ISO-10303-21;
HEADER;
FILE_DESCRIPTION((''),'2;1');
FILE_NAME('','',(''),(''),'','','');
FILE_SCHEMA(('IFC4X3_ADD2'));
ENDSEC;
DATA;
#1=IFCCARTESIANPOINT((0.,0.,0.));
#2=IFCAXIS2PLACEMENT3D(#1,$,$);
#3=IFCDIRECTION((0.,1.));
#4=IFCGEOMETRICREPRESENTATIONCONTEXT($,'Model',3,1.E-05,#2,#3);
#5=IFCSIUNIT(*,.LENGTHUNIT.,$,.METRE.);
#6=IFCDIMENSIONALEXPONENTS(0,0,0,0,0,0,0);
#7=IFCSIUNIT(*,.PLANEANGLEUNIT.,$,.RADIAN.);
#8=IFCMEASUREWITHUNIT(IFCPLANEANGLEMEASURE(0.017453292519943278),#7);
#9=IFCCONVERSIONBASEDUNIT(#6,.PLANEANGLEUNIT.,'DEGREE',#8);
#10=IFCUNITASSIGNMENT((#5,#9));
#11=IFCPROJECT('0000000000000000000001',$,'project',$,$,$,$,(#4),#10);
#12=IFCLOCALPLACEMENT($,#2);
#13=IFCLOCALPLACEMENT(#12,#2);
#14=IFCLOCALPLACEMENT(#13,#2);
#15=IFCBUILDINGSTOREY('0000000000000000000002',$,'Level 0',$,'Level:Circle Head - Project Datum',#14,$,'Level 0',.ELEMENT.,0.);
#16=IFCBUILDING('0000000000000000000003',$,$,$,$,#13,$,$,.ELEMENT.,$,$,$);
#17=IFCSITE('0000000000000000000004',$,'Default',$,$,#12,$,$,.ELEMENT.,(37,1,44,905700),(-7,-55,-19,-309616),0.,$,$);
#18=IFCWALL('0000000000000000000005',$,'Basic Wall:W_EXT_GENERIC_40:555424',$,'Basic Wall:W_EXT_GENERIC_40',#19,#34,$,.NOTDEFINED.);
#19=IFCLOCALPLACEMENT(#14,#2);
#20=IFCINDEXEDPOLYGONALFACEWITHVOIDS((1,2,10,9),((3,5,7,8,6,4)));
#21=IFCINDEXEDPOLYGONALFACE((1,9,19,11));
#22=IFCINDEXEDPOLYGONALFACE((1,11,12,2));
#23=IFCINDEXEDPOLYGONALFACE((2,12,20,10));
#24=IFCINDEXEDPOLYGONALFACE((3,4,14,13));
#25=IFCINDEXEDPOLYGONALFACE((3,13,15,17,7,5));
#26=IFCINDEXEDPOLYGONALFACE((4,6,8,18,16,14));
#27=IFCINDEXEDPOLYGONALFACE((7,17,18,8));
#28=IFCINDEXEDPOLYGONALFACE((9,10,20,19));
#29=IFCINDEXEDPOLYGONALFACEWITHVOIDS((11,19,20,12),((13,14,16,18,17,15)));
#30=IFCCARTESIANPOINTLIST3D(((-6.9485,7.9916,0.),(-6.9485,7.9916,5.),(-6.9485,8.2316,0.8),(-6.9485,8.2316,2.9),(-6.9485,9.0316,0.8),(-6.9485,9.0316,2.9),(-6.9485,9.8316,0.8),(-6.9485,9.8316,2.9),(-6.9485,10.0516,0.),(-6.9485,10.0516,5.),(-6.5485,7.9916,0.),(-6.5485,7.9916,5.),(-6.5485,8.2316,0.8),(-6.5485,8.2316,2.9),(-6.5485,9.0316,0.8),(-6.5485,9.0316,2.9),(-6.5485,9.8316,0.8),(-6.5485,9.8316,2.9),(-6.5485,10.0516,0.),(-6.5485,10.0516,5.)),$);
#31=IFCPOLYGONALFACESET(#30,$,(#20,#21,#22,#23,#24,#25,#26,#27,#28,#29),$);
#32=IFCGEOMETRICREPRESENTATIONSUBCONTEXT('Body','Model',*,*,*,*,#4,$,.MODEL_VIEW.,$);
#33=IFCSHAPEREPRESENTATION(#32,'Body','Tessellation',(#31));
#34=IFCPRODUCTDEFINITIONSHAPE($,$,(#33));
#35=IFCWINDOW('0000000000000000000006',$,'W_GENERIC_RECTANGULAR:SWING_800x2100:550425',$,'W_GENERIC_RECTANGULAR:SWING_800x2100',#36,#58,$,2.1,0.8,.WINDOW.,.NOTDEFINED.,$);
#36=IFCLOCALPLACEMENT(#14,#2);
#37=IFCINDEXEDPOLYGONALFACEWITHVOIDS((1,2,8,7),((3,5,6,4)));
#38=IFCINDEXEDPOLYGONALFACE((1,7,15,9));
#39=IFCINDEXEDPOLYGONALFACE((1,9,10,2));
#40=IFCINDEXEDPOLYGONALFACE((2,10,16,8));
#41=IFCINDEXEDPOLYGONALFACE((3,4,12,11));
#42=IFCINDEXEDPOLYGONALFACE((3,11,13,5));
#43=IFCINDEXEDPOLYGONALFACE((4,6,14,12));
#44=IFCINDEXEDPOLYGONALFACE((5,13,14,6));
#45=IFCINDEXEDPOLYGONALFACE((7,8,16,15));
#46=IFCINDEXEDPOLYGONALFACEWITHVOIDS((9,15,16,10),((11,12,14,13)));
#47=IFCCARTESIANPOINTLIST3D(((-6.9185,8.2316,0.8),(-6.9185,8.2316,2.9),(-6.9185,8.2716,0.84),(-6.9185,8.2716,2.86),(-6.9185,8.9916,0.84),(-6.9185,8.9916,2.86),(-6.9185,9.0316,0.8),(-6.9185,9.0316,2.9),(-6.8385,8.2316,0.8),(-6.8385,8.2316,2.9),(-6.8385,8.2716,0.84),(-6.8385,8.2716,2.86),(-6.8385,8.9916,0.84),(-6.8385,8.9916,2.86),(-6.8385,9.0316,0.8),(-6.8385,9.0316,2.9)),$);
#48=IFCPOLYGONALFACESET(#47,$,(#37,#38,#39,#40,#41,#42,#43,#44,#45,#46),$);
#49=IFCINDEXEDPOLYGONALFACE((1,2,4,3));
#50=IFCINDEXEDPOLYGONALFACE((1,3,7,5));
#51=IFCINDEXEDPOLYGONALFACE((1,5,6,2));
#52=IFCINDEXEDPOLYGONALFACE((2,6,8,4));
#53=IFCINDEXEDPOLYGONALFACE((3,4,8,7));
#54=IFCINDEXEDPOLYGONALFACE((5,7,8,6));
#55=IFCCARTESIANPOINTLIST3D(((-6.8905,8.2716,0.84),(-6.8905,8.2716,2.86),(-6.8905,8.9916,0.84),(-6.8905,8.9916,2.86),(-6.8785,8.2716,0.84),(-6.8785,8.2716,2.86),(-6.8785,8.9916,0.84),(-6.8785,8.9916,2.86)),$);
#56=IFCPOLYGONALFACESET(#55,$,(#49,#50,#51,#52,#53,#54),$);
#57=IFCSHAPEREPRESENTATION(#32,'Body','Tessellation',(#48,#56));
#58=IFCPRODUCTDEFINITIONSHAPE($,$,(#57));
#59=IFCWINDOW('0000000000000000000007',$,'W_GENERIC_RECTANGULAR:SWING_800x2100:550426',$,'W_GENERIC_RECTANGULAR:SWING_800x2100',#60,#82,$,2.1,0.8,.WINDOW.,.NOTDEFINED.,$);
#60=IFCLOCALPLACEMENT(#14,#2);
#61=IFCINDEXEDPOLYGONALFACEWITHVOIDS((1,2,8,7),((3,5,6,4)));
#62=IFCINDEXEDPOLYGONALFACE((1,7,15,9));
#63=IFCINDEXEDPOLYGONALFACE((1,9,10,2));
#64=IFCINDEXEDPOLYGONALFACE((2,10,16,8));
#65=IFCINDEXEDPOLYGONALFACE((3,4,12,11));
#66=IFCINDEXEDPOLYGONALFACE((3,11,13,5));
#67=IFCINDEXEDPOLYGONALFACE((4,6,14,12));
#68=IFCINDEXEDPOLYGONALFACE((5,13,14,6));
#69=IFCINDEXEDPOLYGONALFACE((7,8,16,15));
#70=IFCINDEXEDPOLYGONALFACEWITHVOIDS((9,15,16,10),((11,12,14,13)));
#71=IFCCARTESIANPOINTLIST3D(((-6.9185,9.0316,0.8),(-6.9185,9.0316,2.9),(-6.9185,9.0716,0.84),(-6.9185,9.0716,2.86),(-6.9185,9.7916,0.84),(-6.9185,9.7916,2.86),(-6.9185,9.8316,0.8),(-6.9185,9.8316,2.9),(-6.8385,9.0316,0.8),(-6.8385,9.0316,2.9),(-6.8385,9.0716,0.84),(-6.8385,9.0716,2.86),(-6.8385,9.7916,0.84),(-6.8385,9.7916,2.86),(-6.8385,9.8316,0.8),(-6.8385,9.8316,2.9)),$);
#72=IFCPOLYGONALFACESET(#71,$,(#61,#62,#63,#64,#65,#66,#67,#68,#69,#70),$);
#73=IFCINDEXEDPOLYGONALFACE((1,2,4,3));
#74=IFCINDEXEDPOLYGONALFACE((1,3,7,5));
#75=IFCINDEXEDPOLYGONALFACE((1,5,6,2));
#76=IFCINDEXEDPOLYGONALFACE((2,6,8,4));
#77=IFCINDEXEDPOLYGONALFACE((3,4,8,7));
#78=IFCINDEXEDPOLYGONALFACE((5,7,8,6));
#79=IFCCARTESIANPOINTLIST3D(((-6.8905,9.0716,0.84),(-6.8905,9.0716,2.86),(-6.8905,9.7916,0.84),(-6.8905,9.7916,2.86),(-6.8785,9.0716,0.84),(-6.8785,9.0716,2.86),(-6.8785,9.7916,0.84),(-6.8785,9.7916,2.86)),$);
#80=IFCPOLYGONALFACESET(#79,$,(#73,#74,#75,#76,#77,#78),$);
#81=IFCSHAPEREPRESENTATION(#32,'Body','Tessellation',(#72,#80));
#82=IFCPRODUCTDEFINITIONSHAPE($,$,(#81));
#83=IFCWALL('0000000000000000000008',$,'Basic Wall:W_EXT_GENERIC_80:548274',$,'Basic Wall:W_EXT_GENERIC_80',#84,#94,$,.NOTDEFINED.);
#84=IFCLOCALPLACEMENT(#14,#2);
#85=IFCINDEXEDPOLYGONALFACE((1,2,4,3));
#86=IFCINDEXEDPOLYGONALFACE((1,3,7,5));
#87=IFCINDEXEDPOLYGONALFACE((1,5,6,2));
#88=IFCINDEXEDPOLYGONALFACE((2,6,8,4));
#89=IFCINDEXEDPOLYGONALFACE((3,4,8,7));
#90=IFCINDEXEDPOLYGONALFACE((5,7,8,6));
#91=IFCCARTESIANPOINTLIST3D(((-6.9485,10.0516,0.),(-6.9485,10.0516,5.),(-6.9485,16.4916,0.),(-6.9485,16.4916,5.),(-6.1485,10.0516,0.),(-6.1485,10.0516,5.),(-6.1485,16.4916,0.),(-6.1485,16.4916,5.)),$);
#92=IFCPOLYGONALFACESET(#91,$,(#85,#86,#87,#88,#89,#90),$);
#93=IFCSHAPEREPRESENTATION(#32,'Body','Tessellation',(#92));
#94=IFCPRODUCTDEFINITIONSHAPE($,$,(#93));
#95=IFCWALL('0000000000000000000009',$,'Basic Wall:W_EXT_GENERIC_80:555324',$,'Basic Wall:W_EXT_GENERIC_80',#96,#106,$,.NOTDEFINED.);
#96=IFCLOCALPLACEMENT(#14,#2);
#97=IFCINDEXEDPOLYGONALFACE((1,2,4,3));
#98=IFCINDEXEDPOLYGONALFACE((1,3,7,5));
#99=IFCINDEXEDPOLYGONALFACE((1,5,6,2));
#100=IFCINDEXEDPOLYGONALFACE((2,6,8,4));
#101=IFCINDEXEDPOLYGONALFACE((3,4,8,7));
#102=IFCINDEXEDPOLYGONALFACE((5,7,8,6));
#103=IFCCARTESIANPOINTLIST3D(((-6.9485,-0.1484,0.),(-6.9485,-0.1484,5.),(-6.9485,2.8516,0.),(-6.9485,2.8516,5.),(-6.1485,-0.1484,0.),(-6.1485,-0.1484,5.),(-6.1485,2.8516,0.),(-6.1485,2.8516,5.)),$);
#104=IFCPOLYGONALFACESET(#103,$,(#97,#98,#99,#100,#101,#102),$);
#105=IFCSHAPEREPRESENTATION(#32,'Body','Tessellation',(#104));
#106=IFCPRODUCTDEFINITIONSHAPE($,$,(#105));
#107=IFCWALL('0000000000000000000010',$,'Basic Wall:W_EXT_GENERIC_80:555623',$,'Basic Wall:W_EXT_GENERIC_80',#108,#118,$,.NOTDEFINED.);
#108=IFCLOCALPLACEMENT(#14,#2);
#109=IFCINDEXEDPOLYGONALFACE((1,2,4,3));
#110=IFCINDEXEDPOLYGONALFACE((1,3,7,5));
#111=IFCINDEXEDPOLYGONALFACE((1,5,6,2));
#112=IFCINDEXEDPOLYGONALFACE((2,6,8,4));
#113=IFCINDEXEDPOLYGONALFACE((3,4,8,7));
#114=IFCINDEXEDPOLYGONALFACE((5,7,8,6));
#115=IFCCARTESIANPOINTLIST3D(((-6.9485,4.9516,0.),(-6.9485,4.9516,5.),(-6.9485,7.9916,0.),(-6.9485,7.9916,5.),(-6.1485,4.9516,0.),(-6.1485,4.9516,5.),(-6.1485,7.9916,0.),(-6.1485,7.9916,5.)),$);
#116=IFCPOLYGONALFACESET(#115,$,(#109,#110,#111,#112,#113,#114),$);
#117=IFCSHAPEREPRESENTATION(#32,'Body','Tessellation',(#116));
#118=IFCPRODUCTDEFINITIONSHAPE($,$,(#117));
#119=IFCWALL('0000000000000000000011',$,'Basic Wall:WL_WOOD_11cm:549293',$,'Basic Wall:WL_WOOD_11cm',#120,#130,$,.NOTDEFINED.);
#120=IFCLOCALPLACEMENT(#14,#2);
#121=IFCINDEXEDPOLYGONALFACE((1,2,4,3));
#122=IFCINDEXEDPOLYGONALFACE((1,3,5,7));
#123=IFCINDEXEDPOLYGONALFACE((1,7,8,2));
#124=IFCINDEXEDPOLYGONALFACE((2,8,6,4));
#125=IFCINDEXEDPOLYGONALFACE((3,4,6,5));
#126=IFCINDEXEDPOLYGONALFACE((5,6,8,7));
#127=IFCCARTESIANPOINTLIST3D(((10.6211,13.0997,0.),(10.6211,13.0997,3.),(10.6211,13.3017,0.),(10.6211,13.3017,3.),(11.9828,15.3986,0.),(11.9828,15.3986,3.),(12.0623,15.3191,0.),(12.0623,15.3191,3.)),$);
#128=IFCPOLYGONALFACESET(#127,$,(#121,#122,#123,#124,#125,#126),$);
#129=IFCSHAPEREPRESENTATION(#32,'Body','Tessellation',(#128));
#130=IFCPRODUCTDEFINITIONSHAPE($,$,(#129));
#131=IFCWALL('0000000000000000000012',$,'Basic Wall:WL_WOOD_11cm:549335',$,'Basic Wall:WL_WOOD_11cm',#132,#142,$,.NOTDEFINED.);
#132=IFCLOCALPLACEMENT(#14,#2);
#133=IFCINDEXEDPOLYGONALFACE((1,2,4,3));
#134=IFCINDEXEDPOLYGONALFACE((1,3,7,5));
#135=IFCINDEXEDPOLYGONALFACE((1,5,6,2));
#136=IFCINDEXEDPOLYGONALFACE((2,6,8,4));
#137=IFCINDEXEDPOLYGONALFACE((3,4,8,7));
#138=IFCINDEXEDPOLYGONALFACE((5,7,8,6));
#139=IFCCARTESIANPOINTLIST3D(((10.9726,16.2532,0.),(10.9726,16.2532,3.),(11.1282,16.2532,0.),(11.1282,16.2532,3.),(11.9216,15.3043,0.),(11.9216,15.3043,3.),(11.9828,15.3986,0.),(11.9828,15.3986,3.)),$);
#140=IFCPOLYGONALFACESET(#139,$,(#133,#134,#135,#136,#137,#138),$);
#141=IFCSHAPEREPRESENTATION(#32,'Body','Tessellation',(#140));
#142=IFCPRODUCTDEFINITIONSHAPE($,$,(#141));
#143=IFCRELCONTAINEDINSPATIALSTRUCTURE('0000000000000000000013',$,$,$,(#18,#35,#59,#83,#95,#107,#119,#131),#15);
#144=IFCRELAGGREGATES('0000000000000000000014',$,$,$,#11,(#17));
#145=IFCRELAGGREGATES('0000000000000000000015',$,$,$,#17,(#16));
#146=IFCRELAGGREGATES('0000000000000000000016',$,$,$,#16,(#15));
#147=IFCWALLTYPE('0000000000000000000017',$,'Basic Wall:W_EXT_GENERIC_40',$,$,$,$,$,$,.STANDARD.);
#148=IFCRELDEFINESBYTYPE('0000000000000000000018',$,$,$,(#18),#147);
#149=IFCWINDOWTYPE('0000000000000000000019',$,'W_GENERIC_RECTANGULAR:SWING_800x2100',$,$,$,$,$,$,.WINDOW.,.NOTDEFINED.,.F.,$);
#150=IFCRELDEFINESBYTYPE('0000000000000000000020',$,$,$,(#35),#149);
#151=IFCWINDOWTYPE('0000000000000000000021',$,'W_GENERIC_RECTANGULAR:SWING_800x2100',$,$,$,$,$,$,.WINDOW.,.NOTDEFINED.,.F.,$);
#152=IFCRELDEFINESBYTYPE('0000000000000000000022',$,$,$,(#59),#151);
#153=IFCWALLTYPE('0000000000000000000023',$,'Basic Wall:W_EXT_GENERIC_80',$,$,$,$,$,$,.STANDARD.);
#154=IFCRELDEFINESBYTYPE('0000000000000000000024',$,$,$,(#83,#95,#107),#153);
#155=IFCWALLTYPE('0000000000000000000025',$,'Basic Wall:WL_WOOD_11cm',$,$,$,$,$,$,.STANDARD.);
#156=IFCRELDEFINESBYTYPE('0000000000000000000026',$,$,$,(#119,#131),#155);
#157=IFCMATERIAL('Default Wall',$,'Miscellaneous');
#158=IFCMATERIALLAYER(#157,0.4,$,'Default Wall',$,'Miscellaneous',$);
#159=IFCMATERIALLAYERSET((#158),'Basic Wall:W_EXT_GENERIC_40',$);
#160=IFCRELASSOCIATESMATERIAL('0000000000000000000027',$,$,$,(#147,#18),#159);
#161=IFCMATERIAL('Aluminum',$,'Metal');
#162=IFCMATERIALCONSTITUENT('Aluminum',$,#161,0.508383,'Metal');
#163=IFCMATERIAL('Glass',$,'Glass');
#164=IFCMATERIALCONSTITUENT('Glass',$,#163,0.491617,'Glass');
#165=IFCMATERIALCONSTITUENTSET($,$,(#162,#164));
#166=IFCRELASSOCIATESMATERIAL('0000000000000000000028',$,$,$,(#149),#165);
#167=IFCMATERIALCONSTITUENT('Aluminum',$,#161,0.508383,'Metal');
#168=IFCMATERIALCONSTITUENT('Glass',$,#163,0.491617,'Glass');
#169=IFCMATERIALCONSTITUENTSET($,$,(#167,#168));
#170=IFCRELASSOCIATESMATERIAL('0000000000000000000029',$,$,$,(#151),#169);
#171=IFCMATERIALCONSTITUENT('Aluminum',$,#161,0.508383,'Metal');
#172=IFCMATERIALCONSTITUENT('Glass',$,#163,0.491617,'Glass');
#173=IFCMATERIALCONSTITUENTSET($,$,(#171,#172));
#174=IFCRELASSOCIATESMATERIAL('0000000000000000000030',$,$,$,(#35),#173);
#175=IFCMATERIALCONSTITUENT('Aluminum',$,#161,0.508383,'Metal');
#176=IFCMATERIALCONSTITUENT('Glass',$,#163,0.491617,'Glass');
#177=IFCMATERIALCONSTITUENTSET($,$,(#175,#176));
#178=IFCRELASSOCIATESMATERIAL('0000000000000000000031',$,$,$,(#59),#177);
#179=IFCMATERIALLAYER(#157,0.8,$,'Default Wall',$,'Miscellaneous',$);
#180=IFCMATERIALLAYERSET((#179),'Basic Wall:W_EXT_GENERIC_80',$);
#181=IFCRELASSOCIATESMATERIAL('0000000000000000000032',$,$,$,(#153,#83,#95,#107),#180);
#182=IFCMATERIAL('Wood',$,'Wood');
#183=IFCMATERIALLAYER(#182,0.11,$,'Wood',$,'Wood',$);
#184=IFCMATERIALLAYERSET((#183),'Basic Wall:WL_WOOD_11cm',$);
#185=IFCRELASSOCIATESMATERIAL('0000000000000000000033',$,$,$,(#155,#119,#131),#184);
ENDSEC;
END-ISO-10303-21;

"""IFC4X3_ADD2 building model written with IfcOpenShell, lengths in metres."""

from ifc_helpers import new_model, entity, si_unit, converted_unit, direction, frame, frame_2d, origin, origin_2d_with_axis, place, context, subcontext, project, spatial, polyline, rectangle, outline, extrude, clip, bounded_halfspace, source, transform, mapped, material, layer, layer_set, constituent, constituent_set, type_object, type_shapes, element, fill, save


model = new_model("IFC4X3_ADD2")

# Units and contexts
model_context = context("Model", 3, precision=1e-05, world=origin(), true_north=direction((0.0, 1.0)))
body_context = subcontext(model_context, "Body", "Model", "MODEL_VIEW")
ifc_project = project(units=[si_unit("LENGTHUNIT", "METRE"), converted_unit("PLANEANGLEUNIT", "DEGREE", entity("IfcPlaneAngleMeasure", 0.017453292519943278), si_unit("PLANEANGLEUNIT", "RADIAN"), dimensions=[0, 0, 0, 0, 0, 0, 0])], contexts=[model_context])

# Site, building, storey
site_placement = place(None, origin())
site = spatial("IfcSite", under=ifc_project, at=site_placement, Name="Default", CompositionType="ELEMENT", RefLatitude=(37, 1, 44, 905700), RefLongitude=(-7, -55, -19, -309616), RefElevation=0.0)
building_placement = place(site_placement, origin())
building = spatial("IfcBuilding", under=site, at=building_placement, CompositionType="ELEMENT")
storey_placement = place(building_placement, origin())
storey = spatial("IfcBuildingStorey", under=building, at=storey_placement, Name="Level 0", ObjectType="Level:Circle Head - Project Datum", LongName="Level 0", CompositionType="ELEMENT", Elevation=0.0)

# Shared definitions
ifc_material_1 = material(Name="Default Wall", Category="Miscellaneous")
ifc_layer_1 = layer(ifc_material_1, 0.4, Name="Default Wall", Category="Miscellaneous")
ifc_layer_set_1 = layer_set([ifc_layer_1], Name="Basic Wall:W_EXT_GENERIC_40")
wall_type_1 = type_object("IfcWallType", Name="Basic Wall:W_EXT_GENERIC_40", PredefinedType="STANDARD", material=ifc_layer_set_1)

# Wall, openings, windows
ifc_material_2 = material(Name="Aluminum", Category="Metal")
ifc_material_3 = material(Name="Glass", Category="Glass")
ifc_constituent_1 = constituent(ifc_material_2, Name="Aluminum", Category="Metal", fraction=0.508383)
ifc_constituent_2 = constituent(ifc_material_3, Name="Glass", Category="Glass", fraction=0.491617)
ifc_constituent_set_1 = constituent_set(constituents=[ifc_constituent_1, ifc_constituent_2])
window_type_1 = type_object("IfcWindowType", Name="W_GENERIC_RECTANGULAR:SWING_800x2100", ParameterTakesPrecedence=False, PartitioningType="NOTDEFINED", PredefinedType="WINDOW", material=ifc_constituent_set_1)
shared_shape_1 = source(origin(), body_context, "Body", "SweptSolid", [
    extrude(outline(polyline([(-0.4, -1.05), (0.4, -1.05), (0.4, 1.05), (-0.4, 1.05), (-0.4, -1.05)]), holes=[polyline([(-0.36, 1.01), (0.36, 1.01), (0.36, -1.01), (-0.36, -1.01), (-0.36, 1.01)])]), frame((0.15, 0.11, 1.05), z_axis=(0.0, -1.0, 0.0), x_axis=(1.0, 0.0, 0.0)), (0.0, 0.0, 1.0), 0.08),
    extrude(rectangle(XDim=0.012, YDim=0.72, at=frame_2d((0.0, 0.0), x_axis=(1.0, 0.0))), frame((0.15, 0.064, 0.04), z_axis=(0.0, 0.0, 1.0), x_axis=(0.0, -1.0, 0.0)), (0.0, 0.0, 1.0), 2.02),
])
type_shapes(window_type_1, [shared_shape_1])
ifc_constituent_3 = constituent(ifc_material_2, Name="Aluminum", Category="Metal", fraction=0.508383)
ifc_constituent_4 = constituent(ifc_material_3, Name="Glass", Category="Glass", fraction=0.491617)
ifc_constituent_set_2 = constituent_set(constituents=[ifc_constituent_3, ifc_constituent_4])
window_type_2 = type_object("IfcWindowType", Name="W_GENERIC_RECTANGULAR:SWING_800x2100", ParameterTakesPrecedence=False, PartitioningType="NOTDEFINED", PredefinedType="WINDOW", material=ifc_constituent_set_2)
shared_shape_2 = source(origin(), body_context, "Body", "SweptSolid", [
    extrude(outline(polyline([(-1.05, -0.4), (1.05, -0.4), (1.05, 0.4), (-1.05, 0.4), (-1.05, -0.4)]), holes=[polyline([(1.01, -0.36), (-1.01, -0.36), (-1.01, 0.36), (1.01, 0.36), (1.01, -0.36)])]), frame((0.4, 0.03, 1.05), z_axis=(0.0, 1.0, 0.0), x_axis=(0.0, 0.0, -1.0)), (0.0, 0.0, 1.0), 0.08),
    extrude(rectangle(XDim=0.72, YDim=0.012, at=frame_2d((0.0, 0.0), x_axis=(1.0, 0.0))), frame((0.4, 0.064, 0.04), z_axis=(0.0, 0.0, 1.0), x_axis=(-1.0, 0.0, 0.0)), (0.0, 0.0, 1.0), 2.02),
])
type_shapes(window_type_2, [shared_shape_2])
wall_1_placement = place(storey_placement, frame((-6.7485, 10.0516, 0.0), z_axis=(0.0, 0.0, 1.0), x_axis=(0.0, -1.0, 0.0)))
wall_1 = element("IfcWall", 1, at=wall_1_placement, inside=storey, type_object=wall_type_1, material=ifc_layer_set_1, Name="Basic Wall:W_EXT_GENERIC_40:555424", ObjectType="Basic Wall:W_EXT_GENERIC_40", PredefinedType="NOTDEFINED", context=body_context, shape_type="SweptSolid", body=[
    extrude(rectangle(XDim=2.06, YDim=0.4, at=frame_2d((1.03, 0.0), x_axis=(-1.0, 0.0))), origin(), (0.0, 0.0, 1.0), 5.0),
])
opening_1_placement = place(wall_1_placement, frame((1.02, -0.2, 0.8)))
opening_1 = element("IfcOpeningElement", 2, at=opening_1_placement, cuts=wall_1, PredefinedType="OPENING", context=body_context, shape_type="SweptSolid", body=[
    extrude(rectangle(XDim=2.1, YDim=0.8, at=frame_2d((1.05, 0.4), x_axis=(-1.0, 0.0))), frame((0.0, 0.0, 0.0), z_axis=(0.0, 1.0, 0.0), x_axis=(0.0, 0.0, 1.0)), (0.0, 0.0, 1.0), 0.4),
])
opening_2_placement = place(wall_1_placement, frame((10.0516, 6.7485, 0.8), z_axis=(0.0, 0.0, 1.0), x_axis=(0.0, 1.0, 0.0)))
element("IfcOpeningElement", 3, at=opening_2_placement, cuts=wall_1, PredefinedType="OPENING", context=body_context, shape_type="SweptSolid", body=[
    extrude(rectangle(XDim=2.1, YDim=0.8, at=origin_2d_with_axis()), frame((-8.4725, 8.6316, 1.05), z_axis=(1.0, 0.0, 0.0), x_axis=(0.0, 0.0, -1.0)), (0.0, 0.0, 1.0), 3.048),
])
opening_3_placement = place(wall_1_placement, frame((0.22, -0.2, 0.8)))
opening_3 = element("IfcOpeningElement", 4, at=opening_3_placement, cuts=wall_1, PredefinedType="OPENING", context=body_context, shape_type="SweptSolid", body=[
    extrude(rectangle(XDim=2.1, YDim=0.8, at=frame_2d((1.05, 0.4), x_axis=(-1.0, 0.0))), frame((0.0, 0.0, 0.0), z_axis=(0.0, 1.0, 0.0), x_axis=(0.0, 0.0, 1.0)), (0.0, 0.0, 1.0), 0.4),
])
opening_4_placement = place(wall_1_placement, frame((10.0516, 6.7485, 0.8), z_axis=(0.0, 0.0, 1.0), x_axis=(0.0, 1.0, 0.0)))
element("IfcOpeningElement", 5, at=opening_4_placement, cuts=wall_1, PredefinedType="OPENING", context=body_context, shape_type="SweptSolid", body=[
    extrude(rectangle(XDim=2.1, YDim=0.8, at=frame_2d((0.0, 0.0), x_axis=(0.0, 1.0))), frame((-8.4725, 9.4316, 1.05), z_axis=(1.0, 0.0, 0.0), x_axis=(0.0, -1.0, 0.0)), (0.0, 0.0, 1.0), 3.048),
])
ifc_constituent_5 = constituent(ifc_material_2, Name="Aluminum", Category="Metal", fraction=0.508383)
ifc_constituent_6 = constituent(ifc_material_3, Name="Glass", Category="Glass", fraction=0.491617)
ifc_constituent_set_3 = constituent_set(constituents=[ifc_constituent_5, ifc_constituent_6])
window_1_placement = place(opening_1_placement, frame((0.25, 0.0, 0.0)))
window_1 = element("IfcWindow", 6, at=window_1_placement, inside=storey, type_object=window_type_1, material=ifc_constituent_set_3, Name="W_GENERIC_RECTANGULAR:SWING_800x2100:550425", ObjectType="W_GENERIC_RECTANGULAR:SWING_800x2100", OverallHeight=2.1, OverallWidth=0.8, PartitioningType="NOTDEFINED", PredefinedType="WINDOW", context=body_context, shape_type="MappedRepresentation", body=[
    mapped(shared_shape_1, transform((0.0, 0.0, 0.0), scale=1.0)),
])
fill(opening_1, window_1)
ifc_constituent_7 = constituent(ifc_material_2, Name="Aluminum", Category="Metal", fraction=0.508383)
ifc_constituent_8 = constituent(ifc_material_3, Name="Glass", Category="Glass", fraction=0.491617)
ifc_constituent_set_4 = constituent_set(constituents=[ifc_constituent_7, ifc_constituent_8])
window_2_placement = place(opening_3_placement, origin())
window_2 = element("IfcWindow", 7, at=window_2_placement, inside=storey, type_object=window_type_2, material=ifc_constituent_set_4, Name="W_GENERIC_RECTANGULAR:SWING_800x2100:550426", ObjectType="W_GENERIC_RECTANGULAR:SWING_800x2100", OverallHeight=2.1, OverallWidth=0.8, PartitioningType="NOTDEFINED", PredefinedType="WINDOW", context=body_context, shape_type="MappedRepresentation", body=[
    mapped(shared_shape_2, transform((0.0, 0.0, 0.0), scale=1.0)),
])
fill(opening_3, window_2)

# Walls
ifc_layer_2 = layer(ifc_material_1, 0.8, Name="Default Wall", Category="Miscellaneous")
ifc_layer_set_2 = layer_set([ifc_layer_2], Name="Basic Wall:W_EXT_GENERIC_80")
wall_type_2 = type_object("IfcWallType", Name="Basic Wall:W_EXT_GENERIC_80", PredefinedType="STANDARD", material=ifc_layer_set_2)
wall_2_placement = place(storey_placement, frame((-6.5485, 16.4916, 0.0), z_axis=(0.0, 0.0, 1.0), x_axis=(0.0, -1.0, 0.0)))
element("IfcWall", 8, at=wall_2_placement, inside=storey, type_object=wall_type_2, material=ifc_layer_set_2, Name="Basic Wall:W_EXT_GENERIC_80:548274", ObjectType="Basic Wall:W_EXT_GENERIC_80", PredefinedType="NOTDEFINED", context=body_context, shape_type="SweptSolid", body=[
    extrude(rectangle(XDim=6.44, YDim=0.8, at=frame_2d((3.22, 0.0), x_axis=(-1.0, 0.0))), origin(), (0.0, 0.0, 1.0), 5.0),
])
wall_3_placement = place(storey_placement, frame((-6.5485, 2.8516, 0.0), z_axis=(0.0, 0.0, 1.0), x_axis=(0.0, -1.0, 0.0)))
element("IfcWall", 9, at=wall_3_placement, inside=storey, type_object=wall_type_2, material=ifc_layer_set_2, Name="Basic Wall:W_EXT_GENERIC_80:555324", ObjectType="Basic Wall:W_EXT_GENERIC_80", PredefinedType="NOTDEFINED", context=body_context, shape_type="SweptSolid", body=[
    extrude(rectangle(XDim=3.0, YDim=0.8, at=frame_2d((1.5, 0.0), x_axis=(-1.0, 0.0))), origin(), (0.0, 0.0, 1.0), 5.0),
])
wall_4_placement = place(storey_placement, frame((-6.5485, 7.9916, 0.0), z_axis=(0.0, 0.0, 1.0), x_axis=(0.0, -1.0, 0.0)))
element("IfcWall", 10, at=wall_4_placement, inside=storey, type_object=wall_type_2, material=ifc_layer_set_2, Name="Basic Wall:W_EXT_GENERIC_80:555623", ObjectType="Basic Wall:W_EXT_GENERIC_80", PredefinedType="NOTDEFINED", context=body_context, shape_type="SweptSolid", body=[
    extrude(rectangle(XDim=3.04, YDim=0.8, at=frame_2d((1.52, 0.0), x_axis=(-1.0, 0.0))), origin(), (0.0, 0.0, 1.0), 5.0),
])
ifc_material_4 = material(Name="Wood", Category="Wood")
ifc_layer_3 = layer(ifc_material_4, 0.11, Name="Wood", Category="Wood")
ifc_layer_set_3 = layer_set([ifc_layer_3], Name="Basic Wall:WL_WOOD_11cm")
wall_type_3 = type_object("IfcWallType", Name="Basic Wall:WL_WOOD_11cm", PredefinedType="STANDARD", material=ifc_layer_set_3)
wall_5_placement = place(storey_placement, frame((10.5749, 13.1297, 0.0), z_axis=(0.0, 0.0, 1.0), x_axis=(0.544639, 0.838671, 0.0)))
element("IfcWall", 11, at=wall_5_placement, inside=storey, type_object=wall_type_3, material=ifc_layer_set_3, Name="Basic Wall:WL_WOOD_11cm:549293", ObjectType="Basic Wall:WL_WOOD_11cm", PredefinedType="NOTDEFINED", context=body_context, shape_type="Clipping", body=[
    clip(extrude(outline(polyline([(2.6463, -0.055), (2.6697, 0.055), (2.5572, 0.055), (0.1694, 0.055), (0.0, -0.055), (2.6463, -0.055)])), origin(), (0.0, 0.0, 1.0), 3.0), bounded_halfspace(frame((0.0, -0.055, 3.0), z_axis=(0.0, 0.0, -1.0), x_axis=(0.544639, -0.838671, 0.0)), True, frame((0.0, -0.055, 3.0)), polyline([(0.0, 0.0), (2.6463, 0.0), (2.6697, 0.11), (2.5572, 0.11), (0.1694, 0.11), (0.0, 0.0)]))),
])
wall_6_placement = place(storey_placement, frame((11.9605, 15.3432, 0.0), z_axis=(0.0, 0.0, 1.0), x_axis=(-0.707107, 0.707107, 0.0)))
element("IfcWall", 12, at=wall_6_placement, inside=storey, type_object=wall_type_3, material=ifc_layer_set_3, Name="Basic Wall:WL_WOOD_11cm:549335", ObjectType="Basic Wall:WL_WOOD_11cm", PredefinedType="NOTDEFINED", context=body_context, shape_type="Clipping", body=[
    clip(extrude(outline(polyline([(1.232, -0.055), (1.342, 0.055), (1.1864, 0.055), (0.0, 0.055), (0.0234, -0.055), (1.232, -0.055)])), origin(), (0.0, 0.0, 1.0), 3.0), bounded_halfspace(frame((0.0234, -0.055, 3.0), z_axis=(0.0, 0.0, -1.0), x_axis=(-0.707107, -0.707107, 0.0)), True, frame((0.0234, -0.055, 3.0)), polyline([(0.0, 0.0), (1.2086, 0.0), (1.3186, 0.11), (1.1631, 0.11), (-0.0234, 0.11), (0.0, 0.0)]))),
])

save(model, "model.ifc")
